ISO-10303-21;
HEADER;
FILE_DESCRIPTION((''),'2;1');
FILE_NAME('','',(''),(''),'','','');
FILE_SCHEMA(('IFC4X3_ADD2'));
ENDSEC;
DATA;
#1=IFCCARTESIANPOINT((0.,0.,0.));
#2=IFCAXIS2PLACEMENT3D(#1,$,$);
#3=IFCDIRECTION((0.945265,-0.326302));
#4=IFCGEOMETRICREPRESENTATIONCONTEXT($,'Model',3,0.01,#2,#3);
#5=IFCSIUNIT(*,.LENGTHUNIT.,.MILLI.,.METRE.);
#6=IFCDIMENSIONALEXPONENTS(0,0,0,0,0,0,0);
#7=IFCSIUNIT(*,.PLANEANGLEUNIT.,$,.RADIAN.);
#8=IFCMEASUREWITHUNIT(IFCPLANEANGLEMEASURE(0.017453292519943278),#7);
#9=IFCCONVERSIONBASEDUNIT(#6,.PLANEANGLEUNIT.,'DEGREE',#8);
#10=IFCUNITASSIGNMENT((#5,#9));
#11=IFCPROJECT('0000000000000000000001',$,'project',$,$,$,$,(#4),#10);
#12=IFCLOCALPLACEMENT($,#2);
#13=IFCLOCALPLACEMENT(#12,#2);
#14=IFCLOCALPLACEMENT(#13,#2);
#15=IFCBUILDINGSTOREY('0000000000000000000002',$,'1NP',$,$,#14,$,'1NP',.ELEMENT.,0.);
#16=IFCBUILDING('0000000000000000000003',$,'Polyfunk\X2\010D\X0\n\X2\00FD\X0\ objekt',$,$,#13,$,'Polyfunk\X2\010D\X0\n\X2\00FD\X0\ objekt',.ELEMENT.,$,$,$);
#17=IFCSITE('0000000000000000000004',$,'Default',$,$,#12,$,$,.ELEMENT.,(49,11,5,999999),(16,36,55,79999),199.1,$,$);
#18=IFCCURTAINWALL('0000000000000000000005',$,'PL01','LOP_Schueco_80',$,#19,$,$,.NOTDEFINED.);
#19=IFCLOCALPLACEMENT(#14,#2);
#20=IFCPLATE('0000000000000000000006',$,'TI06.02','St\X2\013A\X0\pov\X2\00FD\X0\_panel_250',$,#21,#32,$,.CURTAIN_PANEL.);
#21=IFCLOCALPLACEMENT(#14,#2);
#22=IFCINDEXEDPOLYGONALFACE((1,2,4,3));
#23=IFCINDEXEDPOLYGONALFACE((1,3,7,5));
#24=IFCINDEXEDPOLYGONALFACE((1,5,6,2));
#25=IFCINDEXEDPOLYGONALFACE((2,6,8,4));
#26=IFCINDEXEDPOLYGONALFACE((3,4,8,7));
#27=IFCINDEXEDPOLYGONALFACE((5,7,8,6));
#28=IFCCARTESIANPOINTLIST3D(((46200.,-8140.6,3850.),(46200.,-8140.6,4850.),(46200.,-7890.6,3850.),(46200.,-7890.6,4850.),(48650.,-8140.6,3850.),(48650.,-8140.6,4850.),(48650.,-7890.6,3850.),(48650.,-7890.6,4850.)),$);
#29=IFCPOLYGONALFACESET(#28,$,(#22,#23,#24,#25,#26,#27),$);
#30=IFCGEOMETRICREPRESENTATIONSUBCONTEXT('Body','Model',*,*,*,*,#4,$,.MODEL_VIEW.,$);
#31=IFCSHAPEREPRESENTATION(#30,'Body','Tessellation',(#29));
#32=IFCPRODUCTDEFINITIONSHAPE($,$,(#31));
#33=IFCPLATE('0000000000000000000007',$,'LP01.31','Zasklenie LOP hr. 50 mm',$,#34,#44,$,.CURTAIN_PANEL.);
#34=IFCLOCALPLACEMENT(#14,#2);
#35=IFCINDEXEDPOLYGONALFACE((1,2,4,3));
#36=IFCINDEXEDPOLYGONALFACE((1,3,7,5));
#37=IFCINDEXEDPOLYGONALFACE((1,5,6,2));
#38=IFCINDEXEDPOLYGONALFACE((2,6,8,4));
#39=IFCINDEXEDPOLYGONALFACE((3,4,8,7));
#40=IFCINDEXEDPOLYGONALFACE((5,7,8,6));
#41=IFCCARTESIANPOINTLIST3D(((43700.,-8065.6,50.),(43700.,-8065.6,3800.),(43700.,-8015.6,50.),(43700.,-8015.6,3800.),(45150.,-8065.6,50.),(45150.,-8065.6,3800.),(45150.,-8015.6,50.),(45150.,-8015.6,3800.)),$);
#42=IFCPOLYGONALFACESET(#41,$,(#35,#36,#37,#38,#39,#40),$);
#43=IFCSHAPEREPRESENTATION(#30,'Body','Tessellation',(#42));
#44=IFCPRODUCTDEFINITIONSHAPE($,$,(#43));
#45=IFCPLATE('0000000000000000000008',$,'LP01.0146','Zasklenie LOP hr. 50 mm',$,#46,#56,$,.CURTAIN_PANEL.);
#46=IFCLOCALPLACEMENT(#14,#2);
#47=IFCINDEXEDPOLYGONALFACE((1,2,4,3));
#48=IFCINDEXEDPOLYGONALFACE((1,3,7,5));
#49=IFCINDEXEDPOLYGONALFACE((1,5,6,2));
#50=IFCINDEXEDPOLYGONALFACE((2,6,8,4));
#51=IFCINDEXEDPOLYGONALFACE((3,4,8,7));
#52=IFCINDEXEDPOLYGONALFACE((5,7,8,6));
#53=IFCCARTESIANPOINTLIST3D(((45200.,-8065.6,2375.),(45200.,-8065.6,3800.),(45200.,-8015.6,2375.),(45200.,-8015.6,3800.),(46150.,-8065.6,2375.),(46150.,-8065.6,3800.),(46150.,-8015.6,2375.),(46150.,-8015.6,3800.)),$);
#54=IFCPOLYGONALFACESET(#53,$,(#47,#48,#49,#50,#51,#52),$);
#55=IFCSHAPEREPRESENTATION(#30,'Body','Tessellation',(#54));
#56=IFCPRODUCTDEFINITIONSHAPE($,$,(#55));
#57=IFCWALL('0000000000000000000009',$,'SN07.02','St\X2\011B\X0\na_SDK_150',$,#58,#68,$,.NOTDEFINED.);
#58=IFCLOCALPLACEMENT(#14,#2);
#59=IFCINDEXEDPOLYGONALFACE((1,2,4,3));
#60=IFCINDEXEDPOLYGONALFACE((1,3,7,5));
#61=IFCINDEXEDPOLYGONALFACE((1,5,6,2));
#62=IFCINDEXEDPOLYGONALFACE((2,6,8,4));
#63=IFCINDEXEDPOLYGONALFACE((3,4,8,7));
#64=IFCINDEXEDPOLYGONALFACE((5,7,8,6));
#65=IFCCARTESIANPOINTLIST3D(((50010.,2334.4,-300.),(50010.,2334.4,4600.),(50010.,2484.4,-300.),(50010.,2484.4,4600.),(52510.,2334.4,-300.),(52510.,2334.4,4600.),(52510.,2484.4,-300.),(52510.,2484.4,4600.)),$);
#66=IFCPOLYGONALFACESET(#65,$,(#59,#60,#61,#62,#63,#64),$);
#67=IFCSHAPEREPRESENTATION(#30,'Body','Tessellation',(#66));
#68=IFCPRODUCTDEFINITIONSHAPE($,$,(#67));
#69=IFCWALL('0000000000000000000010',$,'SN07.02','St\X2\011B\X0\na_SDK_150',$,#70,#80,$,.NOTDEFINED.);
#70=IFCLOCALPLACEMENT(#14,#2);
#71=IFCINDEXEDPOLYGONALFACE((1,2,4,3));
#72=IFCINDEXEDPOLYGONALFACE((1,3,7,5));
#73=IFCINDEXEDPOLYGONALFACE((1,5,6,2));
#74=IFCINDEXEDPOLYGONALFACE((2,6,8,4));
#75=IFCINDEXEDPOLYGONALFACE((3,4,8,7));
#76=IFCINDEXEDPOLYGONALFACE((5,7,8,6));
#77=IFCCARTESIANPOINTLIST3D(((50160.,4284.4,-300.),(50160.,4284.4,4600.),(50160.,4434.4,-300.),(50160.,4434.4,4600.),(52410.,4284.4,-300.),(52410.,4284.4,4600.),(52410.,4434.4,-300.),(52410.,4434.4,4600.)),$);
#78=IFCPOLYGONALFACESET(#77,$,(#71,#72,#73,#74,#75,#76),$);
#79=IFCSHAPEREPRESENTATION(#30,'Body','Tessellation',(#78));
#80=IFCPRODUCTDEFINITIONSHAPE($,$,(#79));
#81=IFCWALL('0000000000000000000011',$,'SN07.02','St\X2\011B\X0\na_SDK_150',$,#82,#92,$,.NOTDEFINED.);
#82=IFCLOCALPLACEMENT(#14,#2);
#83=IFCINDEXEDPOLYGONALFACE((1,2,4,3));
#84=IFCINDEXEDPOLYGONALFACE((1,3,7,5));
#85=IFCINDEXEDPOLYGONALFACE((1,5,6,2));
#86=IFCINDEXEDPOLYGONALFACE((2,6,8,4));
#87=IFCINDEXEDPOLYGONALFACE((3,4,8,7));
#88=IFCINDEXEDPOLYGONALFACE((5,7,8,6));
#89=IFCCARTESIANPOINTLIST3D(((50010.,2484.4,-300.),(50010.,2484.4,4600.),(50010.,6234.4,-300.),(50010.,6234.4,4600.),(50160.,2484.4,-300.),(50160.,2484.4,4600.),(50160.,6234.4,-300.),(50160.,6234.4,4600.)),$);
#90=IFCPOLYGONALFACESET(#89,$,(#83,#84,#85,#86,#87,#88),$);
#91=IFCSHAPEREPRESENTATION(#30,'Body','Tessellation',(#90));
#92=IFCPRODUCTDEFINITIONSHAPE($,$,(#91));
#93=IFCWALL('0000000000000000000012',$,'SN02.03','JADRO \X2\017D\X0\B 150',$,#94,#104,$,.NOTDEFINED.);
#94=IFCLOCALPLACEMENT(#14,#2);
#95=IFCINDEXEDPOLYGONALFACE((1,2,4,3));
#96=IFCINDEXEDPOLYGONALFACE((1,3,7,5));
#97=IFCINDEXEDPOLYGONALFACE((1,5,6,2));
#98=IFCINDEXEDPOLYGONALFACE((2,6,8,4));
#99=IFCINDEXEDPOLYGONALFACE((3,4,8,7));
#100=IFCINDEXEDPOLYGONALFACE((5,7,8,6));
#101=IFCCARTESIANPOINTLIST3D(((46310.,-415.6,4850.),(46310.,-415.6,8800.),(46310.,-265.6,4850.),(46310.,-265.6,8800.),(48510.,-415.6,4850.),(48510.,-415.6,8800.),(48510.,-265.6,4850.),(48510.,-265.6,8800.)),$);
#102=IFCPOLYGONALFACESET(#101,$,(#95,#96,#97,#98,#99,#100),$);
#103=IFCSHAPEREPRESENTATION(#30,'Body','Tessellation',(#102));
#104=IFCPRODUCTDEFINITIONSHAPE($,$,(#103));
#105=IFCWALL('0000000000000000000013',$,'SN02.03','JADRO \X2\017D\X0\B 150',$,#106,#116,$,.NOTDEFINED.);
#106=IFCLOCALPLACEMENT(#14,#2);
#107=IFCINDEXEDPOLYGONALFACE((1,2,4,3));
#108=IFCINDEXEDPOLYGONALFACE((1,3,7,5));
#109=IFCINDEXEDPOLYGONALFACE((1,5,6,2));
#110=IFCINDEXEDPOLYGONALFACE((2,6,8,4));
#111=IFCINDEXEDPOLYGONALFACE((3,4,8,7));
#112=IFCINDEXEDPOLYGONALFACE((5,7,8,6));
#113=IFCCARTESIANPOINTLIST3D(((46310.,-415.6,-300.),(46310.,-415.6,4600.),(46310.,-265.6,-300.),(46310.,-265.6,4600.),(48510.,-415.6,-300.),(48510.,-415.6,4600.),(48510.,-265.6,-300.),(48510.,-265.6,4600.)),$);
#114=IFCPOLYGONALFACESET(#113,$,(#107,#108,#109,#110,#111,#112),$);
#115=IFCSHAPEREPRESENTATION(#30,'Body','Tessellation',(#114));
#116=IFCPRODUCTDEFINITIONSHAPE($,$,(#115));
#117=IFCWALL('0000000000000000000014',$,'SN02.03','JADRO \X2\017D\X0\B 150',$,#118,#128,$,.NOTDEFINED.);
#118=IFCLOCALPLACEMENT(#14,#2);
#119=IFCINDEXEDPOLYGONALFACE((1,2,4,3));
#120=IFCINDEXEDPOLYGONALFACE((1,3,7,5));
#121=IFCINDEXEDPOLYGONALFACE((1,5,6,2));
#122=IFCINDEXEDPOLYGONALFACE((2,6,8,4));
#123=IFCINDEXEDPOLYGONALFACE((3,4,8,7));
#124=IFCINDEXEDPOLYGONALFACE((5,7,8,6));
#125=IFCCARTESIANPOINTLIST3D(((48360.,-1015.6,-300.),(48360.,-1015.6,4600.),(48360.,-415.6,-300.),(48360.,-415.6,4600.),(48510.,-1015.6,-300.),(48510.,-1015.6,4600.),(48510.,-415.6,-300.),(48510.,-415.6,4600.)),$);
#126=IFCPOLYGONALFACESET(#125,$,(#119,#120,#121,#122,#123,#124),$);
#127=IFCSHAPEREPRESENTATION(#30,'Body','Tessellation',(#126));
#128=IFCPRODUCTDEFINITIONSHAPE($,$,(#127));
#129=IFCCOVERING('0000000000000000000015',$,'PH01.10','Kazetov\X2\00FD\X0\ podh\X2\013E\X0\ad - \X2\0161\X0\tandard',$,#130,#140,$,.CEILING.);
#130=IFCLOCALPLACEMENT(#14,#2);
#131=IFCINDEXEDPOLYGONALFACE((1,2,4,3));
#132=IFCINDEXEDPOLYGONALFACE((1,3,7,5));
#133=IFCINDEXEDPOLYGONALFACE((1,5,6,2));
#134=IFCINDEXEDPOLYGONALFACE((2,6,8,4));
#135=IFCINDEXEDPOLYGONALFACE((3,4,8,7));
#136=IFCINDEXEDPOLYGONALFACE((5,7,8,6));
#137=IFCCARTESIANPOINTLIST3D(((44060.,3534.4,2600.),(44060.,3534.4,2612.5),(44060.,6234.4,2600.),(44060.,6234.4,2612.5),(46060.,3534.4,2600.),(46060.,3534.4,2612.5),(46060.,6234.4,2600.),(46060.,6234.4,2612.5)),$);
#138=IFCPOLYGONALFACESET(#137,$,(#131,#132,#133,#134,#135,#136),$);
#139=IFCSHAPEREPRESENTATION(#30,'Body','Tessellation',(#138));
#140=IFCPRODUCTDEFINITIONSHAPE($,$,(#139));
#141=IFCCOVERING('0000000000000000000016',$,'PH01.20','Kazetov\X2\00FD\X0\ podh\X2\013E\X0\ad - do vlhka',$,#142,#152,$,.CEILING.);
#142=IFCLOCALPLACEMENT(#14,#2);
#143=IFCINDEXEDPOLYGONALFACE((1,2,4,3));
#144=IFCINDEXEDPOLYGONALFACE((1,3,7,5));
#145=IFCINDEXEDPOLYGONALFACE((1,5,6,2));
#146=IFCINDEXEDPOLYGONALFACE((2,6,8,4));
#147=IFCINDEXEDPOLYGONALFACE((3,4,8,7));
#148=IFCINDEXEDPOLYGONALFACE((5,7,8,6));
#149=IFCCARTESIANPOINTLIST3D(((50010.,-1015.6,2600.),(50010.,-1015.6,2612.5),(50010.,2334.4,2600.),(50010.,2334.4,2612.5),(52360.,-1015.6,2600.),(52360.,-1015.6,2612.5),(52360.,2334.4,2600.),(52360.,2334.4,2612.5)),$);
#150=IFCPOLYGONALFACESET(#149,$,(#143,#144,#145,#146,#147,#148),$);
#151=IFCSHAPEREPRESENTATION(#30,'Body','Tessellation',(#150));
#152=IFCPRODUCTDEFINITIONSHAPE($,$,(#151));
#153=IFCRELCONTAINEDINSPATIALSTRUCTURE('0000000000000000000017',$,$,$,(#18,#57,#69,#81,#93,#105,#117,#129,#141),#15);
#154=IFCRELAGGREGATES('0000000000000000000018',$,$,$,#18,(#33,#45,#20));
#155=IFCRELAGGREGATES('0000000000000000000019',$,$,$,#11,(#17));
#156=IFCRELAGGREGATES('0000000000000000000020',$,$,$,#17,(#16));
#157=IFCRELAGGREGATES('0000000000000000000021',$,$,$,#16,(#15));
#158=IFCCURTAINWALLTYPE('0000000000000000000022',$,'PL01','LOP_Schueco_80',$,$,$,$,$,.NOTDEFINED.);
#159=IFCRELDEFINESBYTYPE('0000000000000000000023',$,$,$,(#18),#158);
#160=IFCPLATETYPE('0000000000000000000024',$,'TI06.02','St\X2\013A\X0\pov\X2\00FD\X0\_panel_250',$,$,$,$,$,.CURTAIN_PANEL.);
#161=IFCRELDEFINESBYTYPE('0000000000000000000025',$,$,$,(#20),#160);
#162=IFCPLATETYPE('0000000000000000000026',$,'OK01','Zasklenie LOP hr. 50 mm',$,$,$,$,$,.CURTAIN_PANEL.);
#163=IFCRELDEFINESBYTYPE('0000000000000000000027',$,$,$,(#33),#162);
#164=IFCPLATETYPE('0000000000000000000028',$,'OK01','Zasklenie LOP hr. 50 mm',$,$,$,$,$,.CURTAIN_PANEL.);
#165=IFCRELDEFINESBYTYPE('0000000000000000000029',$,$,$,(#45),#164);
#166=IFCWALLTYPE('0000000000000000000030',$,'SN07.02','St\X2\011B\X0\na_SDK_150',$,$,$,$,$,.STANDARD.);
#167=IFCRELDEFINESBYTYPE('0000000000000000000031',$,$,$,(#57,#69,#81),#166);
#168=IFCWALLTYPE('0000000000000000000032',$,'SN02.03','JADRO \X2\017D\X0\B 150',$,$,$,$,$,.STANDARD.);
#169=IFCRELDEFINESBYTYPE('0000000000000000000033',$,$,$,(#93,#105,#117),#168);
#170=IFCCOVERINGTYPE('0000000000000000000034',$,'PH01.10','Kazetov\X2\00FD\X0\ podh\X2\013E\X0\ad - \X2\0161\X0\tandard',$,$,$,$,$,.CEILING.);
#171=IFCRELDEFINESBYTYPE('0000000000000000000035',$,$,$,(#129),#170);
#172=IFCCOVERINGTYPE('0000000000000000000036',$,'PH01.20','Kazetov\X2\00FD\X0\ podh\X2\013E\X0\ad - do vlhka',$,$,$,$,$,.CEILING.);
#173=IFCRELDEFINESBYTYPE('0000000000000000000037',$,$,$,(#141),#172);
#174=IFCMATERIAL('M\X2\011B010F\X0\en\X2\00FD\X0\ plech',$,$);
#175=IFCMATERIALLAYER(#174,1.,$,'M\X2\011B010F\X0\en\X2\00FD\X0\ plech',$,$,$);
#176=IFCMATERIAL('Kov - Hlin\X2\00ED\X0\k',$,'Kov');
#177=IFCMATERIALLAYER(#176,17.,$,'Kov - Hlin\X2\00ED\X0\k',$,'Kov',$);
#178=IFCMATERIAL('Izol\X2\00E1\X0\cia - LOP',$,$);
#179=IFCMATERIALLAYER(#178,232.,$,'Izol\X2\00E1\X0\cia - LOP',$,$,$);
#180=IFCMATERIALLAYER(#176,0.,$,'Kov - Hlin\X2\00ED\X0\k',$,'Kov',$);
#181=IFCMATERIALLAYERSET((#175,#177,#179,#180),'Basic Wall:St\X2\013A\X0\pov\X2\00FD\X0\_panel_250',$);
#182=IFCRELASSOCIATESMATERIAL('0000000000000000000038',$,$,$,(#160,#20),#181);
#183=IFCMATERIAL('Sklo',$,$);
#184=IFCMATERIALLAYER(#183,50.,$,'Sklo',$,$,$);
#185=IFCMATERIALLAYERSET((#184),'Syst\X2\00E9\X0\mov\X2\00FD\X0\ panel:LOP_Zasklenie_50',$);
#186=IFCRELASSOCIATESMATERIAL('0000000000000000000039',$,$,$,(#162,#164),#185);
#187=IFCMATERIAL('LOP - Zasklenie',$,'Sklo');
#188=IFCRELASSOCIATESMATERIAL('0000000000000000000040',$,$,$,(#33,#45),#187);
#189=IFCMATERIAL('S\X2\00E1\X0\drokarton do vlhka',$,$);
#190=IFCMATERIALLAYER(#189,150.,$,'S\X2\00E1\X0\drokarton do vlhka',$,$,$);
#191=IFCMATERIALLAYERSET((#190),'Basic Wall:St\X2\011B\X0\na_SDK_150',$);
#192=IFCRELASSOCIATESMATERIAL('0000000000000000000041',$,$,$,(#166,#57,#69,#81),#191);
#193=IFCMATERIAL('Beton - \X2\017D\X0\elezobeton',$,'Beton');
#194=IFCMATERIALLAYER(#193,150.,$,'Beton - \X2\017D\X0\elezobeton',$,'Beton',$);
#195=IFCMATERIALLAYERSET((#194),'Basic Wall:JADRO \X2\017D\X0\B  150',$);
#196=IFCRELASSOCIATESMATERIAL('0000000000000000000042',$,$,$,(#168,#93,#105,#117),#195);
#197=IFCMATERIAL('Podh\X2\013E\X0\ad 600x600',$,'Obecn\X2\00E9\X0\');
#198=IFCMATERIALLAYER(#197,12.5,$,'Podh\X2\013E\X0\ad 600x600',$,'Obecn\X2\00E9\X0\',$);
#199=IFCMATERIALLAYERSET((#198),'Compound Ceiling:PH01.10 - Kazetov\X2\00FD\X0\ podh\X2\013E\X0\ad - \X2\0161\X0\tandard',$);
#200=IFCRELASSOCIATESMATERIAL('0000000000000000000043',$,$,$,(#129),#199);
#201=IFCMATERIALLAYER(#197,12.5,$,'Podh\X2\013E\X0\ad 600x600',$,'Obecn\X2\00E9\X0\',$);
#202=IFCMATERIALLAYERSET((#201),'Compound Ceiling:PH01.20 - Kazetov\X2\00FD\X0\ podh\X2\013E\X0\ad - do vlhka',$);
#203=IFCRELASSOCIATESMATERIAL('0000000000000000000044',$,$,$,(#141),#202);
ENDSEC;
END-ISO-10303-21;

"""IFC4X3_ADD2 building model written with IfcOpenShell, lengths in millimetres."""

from ifc_helpers import new_model, entity, si_unit, converted_unit, direction, frame, frame_2d, origin, origin_2d_with_axis, place, context, subcontext, project, spatial, polyline, rectangle, extrude, clip, bounded_halfspace, source, transform, mapped, material, layer, layer_set, layer_usage, type_object, type_shapes, element, aggregate, save


model = new_model("IFC4X3_ADD2")

# Units and contexts
model_context = context("Model", 3, precision=0.01, world=origin(), true_north=direction((0.945265, -0.326302)))
body_context = subcontext(model_context, "Body", "Model", "MODEL_VIEW")
ifc_project = project(units=[si_unit("LENGTHUNIT", "METRE", prefix="MILLI"), converted_unit("PLANEANGLEUNIT", "DEGREE", entity("IfcPlaneAngleMeasure", 0.017453292519943278), si_unit("PLANEANGLEUNIT", "RADIAN"), dimensions=[0, 0, 0, 0, 0, 0, 0])], contexts=[model_context])

# Site, building, storey
site_placement = place(None, origin())
site = spatial("IfcSite", under=ifc_project, at=site_placement, Name="Default", CompositionType="ELEMENT", RefLatitude=(49, 11, 5, 999999), RefLongitude=(16, 36, 55, 79999), RefElevation=199.1)
building_placement = place(site_placement, origin())
building = spatial("IfcBuilding", under=site, at=building_placement, Name="Polyfunkčný objekt", LongName="Polyfunkčný objekt", CompositionType="ELEMENT")
storey_placement = place(building_placement, origin())
storey = spatial("IfcBuildingStorey", under=building, at=storey_placement, Name="1NP", LongName="1NP", CompositionType="ELEMENT", Elevation=0.0)

# Curtain wall, plates
curtain_wall_type = type_object("IfcCurtainWallType", Name="PL01", Description="LOP_Schueco_80", PredefinedType="NOTDEFINED")
curtain_wall_placement = place(storey_placement, origin())
curtain_wall = element("IfcCurtainWall", 1, at=curtain_wall_placement, inside=storey, type_object=curtain_wall_type, Name="PL01", Description="LOP_Schueco_80", PredefinedType="NOTDEFINED")
ifc_material_1 = material(Name="Měďený plech")
ifc_layer_1 = layer(ifc_material_1, 1.0, Name="Měďený plech")
ifc_material_2 = material(Name="Kov - Hliník", Category="Kov")
ifc_layer_2 = layer(ifc_material_2, 17.0, Name="Kov - Hliník", Category="Kov")
ifc_material_3 = material(Name="Izolácia - LOP")
ifc_layer_3 = layer(ifc_material_3, 232.0, Name="Izolácia - LOP")
ifc_layer_4 = layer(ifc_material_2, 0.0, Name="Kov - Hliník", Category="Kov")
ifc_layer_set_1 = layer_set([ifc_layer_1, ifc_layer_2, ifc_layer_3, ifc_layer_4], Name="Basic Wall:Stĺpový_panel_250")
ifc_layer_usage_1 = layer_usage(ifc_layer_set_1, "AXIS2", "POSITIVE", -125.0)
plate_type_1 = type_object("IfcPlateType", Name="TI06.02", Description="Stĺpový_panel_250", PredefinedType="CURTAIN_PANEL", material=ifc_layer_set_1)
plate_1_placement = place(storey_placement, frame((46200.0, -8015.6, 3850.0)))
plate_1 = element("IfcPlate", 2, at=plate_1_placement, type_object=plate_type_1, material=ifc_layer_usage_1, Name="TI06.02", Description="Stĺpový_panel_250", PredefinedType="CURTAIN_PANEL", context=body_context, shape_type="SweptSolid", body=[
    extrude(rectangle(XDim=250.0, YDim=2450.0, at=origin_2d_with_axis()), frame((1225.0, 0.0, 0.0), z_axis=(0.0, 0.0, 1.0), x_axis=(0.0, 1.0, 0.0)), (0.0, 0.0, 1.0), 1000.0),
])
ifc_material_4 = material(Name="LOP - Zasklenie", Category="Sklo")
ifc_material_5 = material(Name="Sklo")
ifc_layer_5 = layer(ifc_material_5, 50.0, Name="Sklo")
ifc_layer_set_2 = layer_set([ifc_layer_5], Name="Systémový panel:LOP_Zasklenie_50")
plate_type_2 = type_object("IfcPlateType", Name="OK01", Description="Zasklenie LOP hr. 50 mm", PredefinedType="CURTAIN_PANEL", material=ifc_layer_set_2)
shared_shape_1 = source(origin(), body_context, "Body", "SweptSolid", [
    extrude(rectangle(XDim=3750.0, YDim=1450.0, at=frame_2d((-331.2, 0.0), x_axis=(1.0, 0.0))), frame((0.0, -50.0, 2206.2), z_axis=(0.0, 1.0, 0.0), x_axis=(0.0, 0.0, 1.0)), (0.0, 0.0, 1.0), 50.0),
])
type_shapes(plate_type_2, [shared_shape_1])
plate_2_placement = place(curtain_wall_placement, frame((44425.0, -8015.6, 50.0)))
plate_2 = element("IfcPlate", 3, at=plate_2_placement, type_object=plate_type_2, material=ifc_material_4, Name="LP01.31", Description="Zasklenie LOP hr. 50 mm", PredefinedType="CURTAIN_PANEL", context=body_context, shape_type="MappedRepresentation", body=[
    mapped(shared_shape_1, transform((0.0, 0.0, 0.0), scale=1.0)),
])
plate_type_3 = type_object("IfcPlateType", Name="OK01", Description="Zasklenie LOP hr. 50 mm", PredefinedType="CURTAIN_PANEL", material=ifc_layer_set_2)
shared_shape_2 = source(origin(), body_context, "Body", "SweptSolid", [
    extrude(rectangle(XDim=1425.0, YDim=950.0, at=frame_2d((87.6, 0.0), x_axis=(1.0, 0.0))), frame((0.0, -50.0, 624.9), z_axis=(0.0, 1.0, 0.0), x_axis=(0.0, 0.0, 1.0)), (0.0, 0.0, 1.0), 50.0),
])
type_shapes(plate_type_3, [shared_shape_2])
plate_3_placement = place(curtain_wall_placement, frame((45675.0, -8015.6, 2375.0)))
plate_3 = element("IfcPlate", 4, at=plate_3_placement, type_object=plate_type_3, material=ifc_material_4, Name="LP01.0146", Description="Zasklenie LOP hr. 50 mm", PredefinedType="CURTAIN_PANEL", context=body_context, shape_type="MappedRepresentation", body=[
    mapped(shared_shape_2, transform((0.0, 0.0, 0.0), scale=1.0)),
])
aggregate(curtain_wall, [plate_2, plate_3, plate_1])

# Walls
ifc_material_6 = material(Name="Sádrokarton do vlhka")
ifc_layer_6 = layer(ifc_material_6, 150.0, Name="Sádrokarton do vlhka")
ifc_layer_set_3 = layer_set([ifc_layer_6], Name="Basic Wall:Stěna_SDK_150")
wall_type_1 = type_object("IfcWallType", Name="SN07.02", Description="Stěna_SDK_150", PredefinedType="STANDARD", material=ifc_layer_set_3)
wall_1_placement = place(storey_placement, frame((50010.0, 2409.4, -300.0)))
element("IfcWall", 5, at=wall_1_placement, inside=storey, type_object=wall_type_1, material=ifc_layer_set_3, Name="SN07.02", Description="Stěna_SDK_150", PredefinedType="NOTDEFINED", context=body_context, shape_type="Clipping", body=[
    clip(clip(extrude(rectangle(XDim=2500.0, YDim=150.0, at=frame_2d((1250.0, 0.0), x_axis=(-1.0, 0.0))), origin(), (0.0, 0.0, 1.0), 4900.0), bounded_halfspace(frame((2500.0, -75.0, 0.0), z_axis=(0.0, 0.0, 1.0), x_axis=(0.0, 1.0, 0.0)), True, frame((2500.0, -75.0, 0.0)), polyline([(0.0, 0.0), (0.0, 150.0), (-100.0, 150.0), (-2350.0, 150.0), (-2500.0, 150.0), (-2500.0, 0.0), (-150.0, 0.0), (0.0, 0.0)]))), bounded_halfspace(frame((0.0, -75.0, 4900.0), z_axis=(0.0, 0.0, -1.0), x_axis=(1.0, 0.0, 0.0)), True, frame((0.0, -75.0, 4900.0)), polyline([(0.0, 0.0), (2350.0, 0.0), (2500.0, 0.0), (2500.0, 150.0), (2400.0, 150.0), (150.0, 150.0), (0.0, 150.0), (0.0, 0.0)]))),
])
wall_2_placement = place(storey_placement, frame((50160.0, 4359.4, -300.0)))
element("IfcWall", 6, at=wall_2_placement, inside=storey, type_object=wall_type_1, material=ifc_layer_set_3, Name="SN07.02", Description="Stěna_SDK_150", PredefinedType="NOTDEFINED", context=body_context, shape_type="Clipping", body=[
    clip(clip(extrude(rectangle(XDim=2250.0, YDim=150.0, at=frame_2d((1125.0, 0.0), x_axis=(-1.0, 0.0))), origin(), (0.0, 0.0, 1.0), 4900.0), bounded_halfspace(frame((2250.0, -75.0, 0.0), z_axis=(0.0, 0.0, 1.0), x_axis=(0.0, 1.0, 0.0)), True, frame((2250.0, -75.0, 0.0)), polyline([(0.0, 0.0), (0.0, 150.0), (-2250.0, 150.0), (-2250.0, 0.0), (0.0, 0.0)]))), bounded_halfspace(frame((0.0, -75.0, 4900.0), z_axis=(0.0, 0.0, -1.0), x_axis=(1.0, 0.0, 0.0)), True, frame((0.0, -75.0, 4900.0)), polyline([(0.0, 0.0), (2250.0, 0.0), (2250.0, 150.0), (0.0, 150.0), (0.0, 0.0)]))),
])
wall_3_placement = place(storey_placement, frame((50085.0, 2484.4, -300.0), z_axis=(0.0, 0.0, 1.0), x_axis=(0.0, 1.0, 0.0)))
element("IfcWall", 7, at=wall_3_placement, inside=storey, type_object=wall_type_1, material=ifc_layer_set_3, Name="SN07.02", Description="Stěna_SDK_150", PredefinedType="NOTDEFINED", context=body_context, shape_type="Clipping", body=[
    clip(clip(extrude(rectangle(XDim=3750.0, YDim=150.0, at=frame_2d((1875.0, 0.0), x_axis=(-1.0, 0.0))), origin(), (0.0, 0.0, 1.0), 4900.0), bounded_halfspace(frame((0.0, -75.0, 4900.0), z_axis=(0.0, 0.0, -1.0), x_axis=(0.0, -1.0, 0.0)), True, frame((0.0, -75.0, 4900.0)), polyline([(0.0, 0.0), (1800.0, 0.0), (1950.0, 0.0), (3750.0, 0.0), (3750.0, 150.0), (0.0, 150.0), (0.0, 0.0)]))), bounded_halfspace(frame((3750.0, -75.0, 0.0)), True, frame((3750.0, -75.0, 0.0)), polyline([(0.0, 0.0), (0.0, 150.0), (-3750.0, 150.0), (-3750.0, 0.0), (-1950.0, 0.0), (-1800.0, 0.0), (0.0, 0.0)]))),
])
ifc_material_7 = material(Name="Beton - Železobeton", Category="Beton")
ifc_layer_7 = layer(ifc_material_7, 150.0, Name="Beton - Železobeton", Category="Beton")
ifc_layer_set_4 = layer_set([ifc_layer_7], Name="Basic Wall:JADRO ŽB  150")
wall_type_2 = type_object("IfcWallType", Name="SN02.03", Description="JADRO ŽB 150", PredefinedType="STANDARD", material=ifc_layer_set_4)
wall_4_placement = place(storey_placement, frame((46310.0, -340.6, 4850.0)))
element("IfcWall", 8, at=wall_4_placement, inside=storey, type_object=wall_type_2, material=ifc_layer_set_4, Name="SN02.03", Description="JADRO ŽB 150", PredefinedType="NOTDEFINED", context=body_context, shape_type="Clipping", body=[
    clip(clip(extrude(rectangle(XDim=2200.0, YDim=150.0, at=frame_2d((1100.0, 0.0), x_axis=(-1.0, 0.0))), origin(), (0.0, 0.0, 1.0), 3950.0), bounded_halfspace(frame((2200.0, -75.0, 0.0), z_axis=(0.0, 0.0, 1.0), x_axis=(-1.0, 0.0, 0.0)), True, frame((2200.0, -75.0, 0.0)), polyline([(0.0, 0.0), (0.0, 150.0), (-2200.0, 150.0), (-2200.0, 0.0), (0.0, 0.0)]))), bounded_halfspace(frame((0.0, -75.0, 3950.0), z_axis=(0.0, 0.0, -1.0), x_axis=(1.0, 0.0, 0.0)), True, frame((0.0, -75.0, 3950.0)), polyline([(0.0, 0.0), (2050.0, 0.0), (2200.0, 0.0), (2200.0, 150.0), (0.0, 150.0), (0.0, 0.0)]))),
])
wall_5_placement = place(storey_placement, frame((46310.0, -340.6, -300.0)))
element("IfcWall", 9, at=wall_5_placement, inside=storey, type_object=wall_type_2, material=ifc_layer_set_4, Name="SN02.03", Description="JADRO ŽB 150", PredefinedType="NOTDEFINED", context=body_context, shape_type="SweptSolid", body=[
    extrude(rectangle(XDim=2200.0, YDim=150.0, at=frame_2d((1100.0, 0.0), x_axis=(-1.0, 0.0))), origin(), (0.0, 0.0, 1.0), 4900.0),
])
wall_6_placement = place(storey_placement, frame((48435.0, -1015.6, -300.0), z_axis=(0.0, 0.0, 1.0), x_axis=(0.0, 1.0, 0.0)))
element("IfcWall", 10, at=wall_6_placement, inside=storey, type_object=wall_type_2, material=ifc_layer_set_4, Name="SN02.03", Description="JADRO ŽB 150", PredefinedType="NOTDEFINED", context=body_context, shape_type="SweptSolid", body=[
    extrude(rectangle(XDim=600.0, YDim=150.0, at=frame_2d((300.0, 0.0), x_axis=(-1.0, 0.0))), origin(), (0.0, 0.0, 1.0), 4900.0),
])

# Coverings
ifc_material_8 = material(Name="Podhľad 600x600", Category="Obecné")
ifc_layer_8 = layer(ifc_material_8, 12.5, Name="Podhľad 600x600", Category="Obecné")
ifc_layer_set_5 = layer_set([ifc_layer_8], Name="Compound Ceiling:PH01.10 - Kazetový podhľad - štandard")
ifc_layer_usage_2 = layer_usage(ifc_layer_set_5, "AXIS3", "NEGATIVE", 0.0)
covering_type_1 = type_object("IfcCoveringType", Name="PH01.10", Description="Kazetový podhľad - štandard", PredefinedType="CEILING")
covering_1_placement = place(storey_placement, frame((44060.0, 3534.4, 2600.0)))
element("IfcCovering", 11, at=covering_1_placement, inside=storey, type_object=covering_type_1, material=ifc_layer_usage_2, Name="PH01.10", Description="Kazetový podhľad - štandard", PredefinedType="CEILING", context=body_context, shape_type="SweptSolid", body=[
    extrude(rectangle(XDim=2000.0, YDim=2700.0, at=frame_2d((0.0, 0.0), x_axis=(1.0, 0.0))), frame((1000.0, 1350.0, 0.0)), (0.0, 0.0, 1.0), 12.5),
])
ifc_layer_9 = layer(ifc_material_8, 12.5, Name="Podhľad 600x600", Category="Obecné")
ifc_layer_set_6 = layer_set([ifc_layer_9], Name="Compound Ceiling:PH01.20 - Kazetový podhľad - do vlhka")
ifc_layer_usage_3 = layer_usage(ifc_layer_set_6, "AXIS3", "NEGATIVE", 12.5)
covering_type_2 = type_object("IfcCoveringType", Name="PH01.20", Description="Kazetový podhľad - do vlhka", PredefinedType="CEILING")
covering_2_placement = place(storey_placement, frame((50010.0, -1015.6, 2600.0)))
element("IfcCovering", 12, at=covering_2_placement, inside=storey, type_object=covering_type_2, material=ifc_layer_usage_3, Name="PH01.20", Description="Kazetový podhľad - do vlhka", PredefinedType="CEILING", context=body_context, shape_type="SweptSolid", body=[
    extrude(rectangle(XDim=3350.0, YDim=2350.0, at=frame_2d((0.0, 0.0), x_axis=(1.0, 0.0))), frame((1175.0, 1675.0, 0.0), z_axis=(0.0, 0.0, 1.0), x_axis=(0.0, 1.0, 0.0)), (0.0, 0.0, 1.0), 12.5),
])

save(model, "model.ifc")
